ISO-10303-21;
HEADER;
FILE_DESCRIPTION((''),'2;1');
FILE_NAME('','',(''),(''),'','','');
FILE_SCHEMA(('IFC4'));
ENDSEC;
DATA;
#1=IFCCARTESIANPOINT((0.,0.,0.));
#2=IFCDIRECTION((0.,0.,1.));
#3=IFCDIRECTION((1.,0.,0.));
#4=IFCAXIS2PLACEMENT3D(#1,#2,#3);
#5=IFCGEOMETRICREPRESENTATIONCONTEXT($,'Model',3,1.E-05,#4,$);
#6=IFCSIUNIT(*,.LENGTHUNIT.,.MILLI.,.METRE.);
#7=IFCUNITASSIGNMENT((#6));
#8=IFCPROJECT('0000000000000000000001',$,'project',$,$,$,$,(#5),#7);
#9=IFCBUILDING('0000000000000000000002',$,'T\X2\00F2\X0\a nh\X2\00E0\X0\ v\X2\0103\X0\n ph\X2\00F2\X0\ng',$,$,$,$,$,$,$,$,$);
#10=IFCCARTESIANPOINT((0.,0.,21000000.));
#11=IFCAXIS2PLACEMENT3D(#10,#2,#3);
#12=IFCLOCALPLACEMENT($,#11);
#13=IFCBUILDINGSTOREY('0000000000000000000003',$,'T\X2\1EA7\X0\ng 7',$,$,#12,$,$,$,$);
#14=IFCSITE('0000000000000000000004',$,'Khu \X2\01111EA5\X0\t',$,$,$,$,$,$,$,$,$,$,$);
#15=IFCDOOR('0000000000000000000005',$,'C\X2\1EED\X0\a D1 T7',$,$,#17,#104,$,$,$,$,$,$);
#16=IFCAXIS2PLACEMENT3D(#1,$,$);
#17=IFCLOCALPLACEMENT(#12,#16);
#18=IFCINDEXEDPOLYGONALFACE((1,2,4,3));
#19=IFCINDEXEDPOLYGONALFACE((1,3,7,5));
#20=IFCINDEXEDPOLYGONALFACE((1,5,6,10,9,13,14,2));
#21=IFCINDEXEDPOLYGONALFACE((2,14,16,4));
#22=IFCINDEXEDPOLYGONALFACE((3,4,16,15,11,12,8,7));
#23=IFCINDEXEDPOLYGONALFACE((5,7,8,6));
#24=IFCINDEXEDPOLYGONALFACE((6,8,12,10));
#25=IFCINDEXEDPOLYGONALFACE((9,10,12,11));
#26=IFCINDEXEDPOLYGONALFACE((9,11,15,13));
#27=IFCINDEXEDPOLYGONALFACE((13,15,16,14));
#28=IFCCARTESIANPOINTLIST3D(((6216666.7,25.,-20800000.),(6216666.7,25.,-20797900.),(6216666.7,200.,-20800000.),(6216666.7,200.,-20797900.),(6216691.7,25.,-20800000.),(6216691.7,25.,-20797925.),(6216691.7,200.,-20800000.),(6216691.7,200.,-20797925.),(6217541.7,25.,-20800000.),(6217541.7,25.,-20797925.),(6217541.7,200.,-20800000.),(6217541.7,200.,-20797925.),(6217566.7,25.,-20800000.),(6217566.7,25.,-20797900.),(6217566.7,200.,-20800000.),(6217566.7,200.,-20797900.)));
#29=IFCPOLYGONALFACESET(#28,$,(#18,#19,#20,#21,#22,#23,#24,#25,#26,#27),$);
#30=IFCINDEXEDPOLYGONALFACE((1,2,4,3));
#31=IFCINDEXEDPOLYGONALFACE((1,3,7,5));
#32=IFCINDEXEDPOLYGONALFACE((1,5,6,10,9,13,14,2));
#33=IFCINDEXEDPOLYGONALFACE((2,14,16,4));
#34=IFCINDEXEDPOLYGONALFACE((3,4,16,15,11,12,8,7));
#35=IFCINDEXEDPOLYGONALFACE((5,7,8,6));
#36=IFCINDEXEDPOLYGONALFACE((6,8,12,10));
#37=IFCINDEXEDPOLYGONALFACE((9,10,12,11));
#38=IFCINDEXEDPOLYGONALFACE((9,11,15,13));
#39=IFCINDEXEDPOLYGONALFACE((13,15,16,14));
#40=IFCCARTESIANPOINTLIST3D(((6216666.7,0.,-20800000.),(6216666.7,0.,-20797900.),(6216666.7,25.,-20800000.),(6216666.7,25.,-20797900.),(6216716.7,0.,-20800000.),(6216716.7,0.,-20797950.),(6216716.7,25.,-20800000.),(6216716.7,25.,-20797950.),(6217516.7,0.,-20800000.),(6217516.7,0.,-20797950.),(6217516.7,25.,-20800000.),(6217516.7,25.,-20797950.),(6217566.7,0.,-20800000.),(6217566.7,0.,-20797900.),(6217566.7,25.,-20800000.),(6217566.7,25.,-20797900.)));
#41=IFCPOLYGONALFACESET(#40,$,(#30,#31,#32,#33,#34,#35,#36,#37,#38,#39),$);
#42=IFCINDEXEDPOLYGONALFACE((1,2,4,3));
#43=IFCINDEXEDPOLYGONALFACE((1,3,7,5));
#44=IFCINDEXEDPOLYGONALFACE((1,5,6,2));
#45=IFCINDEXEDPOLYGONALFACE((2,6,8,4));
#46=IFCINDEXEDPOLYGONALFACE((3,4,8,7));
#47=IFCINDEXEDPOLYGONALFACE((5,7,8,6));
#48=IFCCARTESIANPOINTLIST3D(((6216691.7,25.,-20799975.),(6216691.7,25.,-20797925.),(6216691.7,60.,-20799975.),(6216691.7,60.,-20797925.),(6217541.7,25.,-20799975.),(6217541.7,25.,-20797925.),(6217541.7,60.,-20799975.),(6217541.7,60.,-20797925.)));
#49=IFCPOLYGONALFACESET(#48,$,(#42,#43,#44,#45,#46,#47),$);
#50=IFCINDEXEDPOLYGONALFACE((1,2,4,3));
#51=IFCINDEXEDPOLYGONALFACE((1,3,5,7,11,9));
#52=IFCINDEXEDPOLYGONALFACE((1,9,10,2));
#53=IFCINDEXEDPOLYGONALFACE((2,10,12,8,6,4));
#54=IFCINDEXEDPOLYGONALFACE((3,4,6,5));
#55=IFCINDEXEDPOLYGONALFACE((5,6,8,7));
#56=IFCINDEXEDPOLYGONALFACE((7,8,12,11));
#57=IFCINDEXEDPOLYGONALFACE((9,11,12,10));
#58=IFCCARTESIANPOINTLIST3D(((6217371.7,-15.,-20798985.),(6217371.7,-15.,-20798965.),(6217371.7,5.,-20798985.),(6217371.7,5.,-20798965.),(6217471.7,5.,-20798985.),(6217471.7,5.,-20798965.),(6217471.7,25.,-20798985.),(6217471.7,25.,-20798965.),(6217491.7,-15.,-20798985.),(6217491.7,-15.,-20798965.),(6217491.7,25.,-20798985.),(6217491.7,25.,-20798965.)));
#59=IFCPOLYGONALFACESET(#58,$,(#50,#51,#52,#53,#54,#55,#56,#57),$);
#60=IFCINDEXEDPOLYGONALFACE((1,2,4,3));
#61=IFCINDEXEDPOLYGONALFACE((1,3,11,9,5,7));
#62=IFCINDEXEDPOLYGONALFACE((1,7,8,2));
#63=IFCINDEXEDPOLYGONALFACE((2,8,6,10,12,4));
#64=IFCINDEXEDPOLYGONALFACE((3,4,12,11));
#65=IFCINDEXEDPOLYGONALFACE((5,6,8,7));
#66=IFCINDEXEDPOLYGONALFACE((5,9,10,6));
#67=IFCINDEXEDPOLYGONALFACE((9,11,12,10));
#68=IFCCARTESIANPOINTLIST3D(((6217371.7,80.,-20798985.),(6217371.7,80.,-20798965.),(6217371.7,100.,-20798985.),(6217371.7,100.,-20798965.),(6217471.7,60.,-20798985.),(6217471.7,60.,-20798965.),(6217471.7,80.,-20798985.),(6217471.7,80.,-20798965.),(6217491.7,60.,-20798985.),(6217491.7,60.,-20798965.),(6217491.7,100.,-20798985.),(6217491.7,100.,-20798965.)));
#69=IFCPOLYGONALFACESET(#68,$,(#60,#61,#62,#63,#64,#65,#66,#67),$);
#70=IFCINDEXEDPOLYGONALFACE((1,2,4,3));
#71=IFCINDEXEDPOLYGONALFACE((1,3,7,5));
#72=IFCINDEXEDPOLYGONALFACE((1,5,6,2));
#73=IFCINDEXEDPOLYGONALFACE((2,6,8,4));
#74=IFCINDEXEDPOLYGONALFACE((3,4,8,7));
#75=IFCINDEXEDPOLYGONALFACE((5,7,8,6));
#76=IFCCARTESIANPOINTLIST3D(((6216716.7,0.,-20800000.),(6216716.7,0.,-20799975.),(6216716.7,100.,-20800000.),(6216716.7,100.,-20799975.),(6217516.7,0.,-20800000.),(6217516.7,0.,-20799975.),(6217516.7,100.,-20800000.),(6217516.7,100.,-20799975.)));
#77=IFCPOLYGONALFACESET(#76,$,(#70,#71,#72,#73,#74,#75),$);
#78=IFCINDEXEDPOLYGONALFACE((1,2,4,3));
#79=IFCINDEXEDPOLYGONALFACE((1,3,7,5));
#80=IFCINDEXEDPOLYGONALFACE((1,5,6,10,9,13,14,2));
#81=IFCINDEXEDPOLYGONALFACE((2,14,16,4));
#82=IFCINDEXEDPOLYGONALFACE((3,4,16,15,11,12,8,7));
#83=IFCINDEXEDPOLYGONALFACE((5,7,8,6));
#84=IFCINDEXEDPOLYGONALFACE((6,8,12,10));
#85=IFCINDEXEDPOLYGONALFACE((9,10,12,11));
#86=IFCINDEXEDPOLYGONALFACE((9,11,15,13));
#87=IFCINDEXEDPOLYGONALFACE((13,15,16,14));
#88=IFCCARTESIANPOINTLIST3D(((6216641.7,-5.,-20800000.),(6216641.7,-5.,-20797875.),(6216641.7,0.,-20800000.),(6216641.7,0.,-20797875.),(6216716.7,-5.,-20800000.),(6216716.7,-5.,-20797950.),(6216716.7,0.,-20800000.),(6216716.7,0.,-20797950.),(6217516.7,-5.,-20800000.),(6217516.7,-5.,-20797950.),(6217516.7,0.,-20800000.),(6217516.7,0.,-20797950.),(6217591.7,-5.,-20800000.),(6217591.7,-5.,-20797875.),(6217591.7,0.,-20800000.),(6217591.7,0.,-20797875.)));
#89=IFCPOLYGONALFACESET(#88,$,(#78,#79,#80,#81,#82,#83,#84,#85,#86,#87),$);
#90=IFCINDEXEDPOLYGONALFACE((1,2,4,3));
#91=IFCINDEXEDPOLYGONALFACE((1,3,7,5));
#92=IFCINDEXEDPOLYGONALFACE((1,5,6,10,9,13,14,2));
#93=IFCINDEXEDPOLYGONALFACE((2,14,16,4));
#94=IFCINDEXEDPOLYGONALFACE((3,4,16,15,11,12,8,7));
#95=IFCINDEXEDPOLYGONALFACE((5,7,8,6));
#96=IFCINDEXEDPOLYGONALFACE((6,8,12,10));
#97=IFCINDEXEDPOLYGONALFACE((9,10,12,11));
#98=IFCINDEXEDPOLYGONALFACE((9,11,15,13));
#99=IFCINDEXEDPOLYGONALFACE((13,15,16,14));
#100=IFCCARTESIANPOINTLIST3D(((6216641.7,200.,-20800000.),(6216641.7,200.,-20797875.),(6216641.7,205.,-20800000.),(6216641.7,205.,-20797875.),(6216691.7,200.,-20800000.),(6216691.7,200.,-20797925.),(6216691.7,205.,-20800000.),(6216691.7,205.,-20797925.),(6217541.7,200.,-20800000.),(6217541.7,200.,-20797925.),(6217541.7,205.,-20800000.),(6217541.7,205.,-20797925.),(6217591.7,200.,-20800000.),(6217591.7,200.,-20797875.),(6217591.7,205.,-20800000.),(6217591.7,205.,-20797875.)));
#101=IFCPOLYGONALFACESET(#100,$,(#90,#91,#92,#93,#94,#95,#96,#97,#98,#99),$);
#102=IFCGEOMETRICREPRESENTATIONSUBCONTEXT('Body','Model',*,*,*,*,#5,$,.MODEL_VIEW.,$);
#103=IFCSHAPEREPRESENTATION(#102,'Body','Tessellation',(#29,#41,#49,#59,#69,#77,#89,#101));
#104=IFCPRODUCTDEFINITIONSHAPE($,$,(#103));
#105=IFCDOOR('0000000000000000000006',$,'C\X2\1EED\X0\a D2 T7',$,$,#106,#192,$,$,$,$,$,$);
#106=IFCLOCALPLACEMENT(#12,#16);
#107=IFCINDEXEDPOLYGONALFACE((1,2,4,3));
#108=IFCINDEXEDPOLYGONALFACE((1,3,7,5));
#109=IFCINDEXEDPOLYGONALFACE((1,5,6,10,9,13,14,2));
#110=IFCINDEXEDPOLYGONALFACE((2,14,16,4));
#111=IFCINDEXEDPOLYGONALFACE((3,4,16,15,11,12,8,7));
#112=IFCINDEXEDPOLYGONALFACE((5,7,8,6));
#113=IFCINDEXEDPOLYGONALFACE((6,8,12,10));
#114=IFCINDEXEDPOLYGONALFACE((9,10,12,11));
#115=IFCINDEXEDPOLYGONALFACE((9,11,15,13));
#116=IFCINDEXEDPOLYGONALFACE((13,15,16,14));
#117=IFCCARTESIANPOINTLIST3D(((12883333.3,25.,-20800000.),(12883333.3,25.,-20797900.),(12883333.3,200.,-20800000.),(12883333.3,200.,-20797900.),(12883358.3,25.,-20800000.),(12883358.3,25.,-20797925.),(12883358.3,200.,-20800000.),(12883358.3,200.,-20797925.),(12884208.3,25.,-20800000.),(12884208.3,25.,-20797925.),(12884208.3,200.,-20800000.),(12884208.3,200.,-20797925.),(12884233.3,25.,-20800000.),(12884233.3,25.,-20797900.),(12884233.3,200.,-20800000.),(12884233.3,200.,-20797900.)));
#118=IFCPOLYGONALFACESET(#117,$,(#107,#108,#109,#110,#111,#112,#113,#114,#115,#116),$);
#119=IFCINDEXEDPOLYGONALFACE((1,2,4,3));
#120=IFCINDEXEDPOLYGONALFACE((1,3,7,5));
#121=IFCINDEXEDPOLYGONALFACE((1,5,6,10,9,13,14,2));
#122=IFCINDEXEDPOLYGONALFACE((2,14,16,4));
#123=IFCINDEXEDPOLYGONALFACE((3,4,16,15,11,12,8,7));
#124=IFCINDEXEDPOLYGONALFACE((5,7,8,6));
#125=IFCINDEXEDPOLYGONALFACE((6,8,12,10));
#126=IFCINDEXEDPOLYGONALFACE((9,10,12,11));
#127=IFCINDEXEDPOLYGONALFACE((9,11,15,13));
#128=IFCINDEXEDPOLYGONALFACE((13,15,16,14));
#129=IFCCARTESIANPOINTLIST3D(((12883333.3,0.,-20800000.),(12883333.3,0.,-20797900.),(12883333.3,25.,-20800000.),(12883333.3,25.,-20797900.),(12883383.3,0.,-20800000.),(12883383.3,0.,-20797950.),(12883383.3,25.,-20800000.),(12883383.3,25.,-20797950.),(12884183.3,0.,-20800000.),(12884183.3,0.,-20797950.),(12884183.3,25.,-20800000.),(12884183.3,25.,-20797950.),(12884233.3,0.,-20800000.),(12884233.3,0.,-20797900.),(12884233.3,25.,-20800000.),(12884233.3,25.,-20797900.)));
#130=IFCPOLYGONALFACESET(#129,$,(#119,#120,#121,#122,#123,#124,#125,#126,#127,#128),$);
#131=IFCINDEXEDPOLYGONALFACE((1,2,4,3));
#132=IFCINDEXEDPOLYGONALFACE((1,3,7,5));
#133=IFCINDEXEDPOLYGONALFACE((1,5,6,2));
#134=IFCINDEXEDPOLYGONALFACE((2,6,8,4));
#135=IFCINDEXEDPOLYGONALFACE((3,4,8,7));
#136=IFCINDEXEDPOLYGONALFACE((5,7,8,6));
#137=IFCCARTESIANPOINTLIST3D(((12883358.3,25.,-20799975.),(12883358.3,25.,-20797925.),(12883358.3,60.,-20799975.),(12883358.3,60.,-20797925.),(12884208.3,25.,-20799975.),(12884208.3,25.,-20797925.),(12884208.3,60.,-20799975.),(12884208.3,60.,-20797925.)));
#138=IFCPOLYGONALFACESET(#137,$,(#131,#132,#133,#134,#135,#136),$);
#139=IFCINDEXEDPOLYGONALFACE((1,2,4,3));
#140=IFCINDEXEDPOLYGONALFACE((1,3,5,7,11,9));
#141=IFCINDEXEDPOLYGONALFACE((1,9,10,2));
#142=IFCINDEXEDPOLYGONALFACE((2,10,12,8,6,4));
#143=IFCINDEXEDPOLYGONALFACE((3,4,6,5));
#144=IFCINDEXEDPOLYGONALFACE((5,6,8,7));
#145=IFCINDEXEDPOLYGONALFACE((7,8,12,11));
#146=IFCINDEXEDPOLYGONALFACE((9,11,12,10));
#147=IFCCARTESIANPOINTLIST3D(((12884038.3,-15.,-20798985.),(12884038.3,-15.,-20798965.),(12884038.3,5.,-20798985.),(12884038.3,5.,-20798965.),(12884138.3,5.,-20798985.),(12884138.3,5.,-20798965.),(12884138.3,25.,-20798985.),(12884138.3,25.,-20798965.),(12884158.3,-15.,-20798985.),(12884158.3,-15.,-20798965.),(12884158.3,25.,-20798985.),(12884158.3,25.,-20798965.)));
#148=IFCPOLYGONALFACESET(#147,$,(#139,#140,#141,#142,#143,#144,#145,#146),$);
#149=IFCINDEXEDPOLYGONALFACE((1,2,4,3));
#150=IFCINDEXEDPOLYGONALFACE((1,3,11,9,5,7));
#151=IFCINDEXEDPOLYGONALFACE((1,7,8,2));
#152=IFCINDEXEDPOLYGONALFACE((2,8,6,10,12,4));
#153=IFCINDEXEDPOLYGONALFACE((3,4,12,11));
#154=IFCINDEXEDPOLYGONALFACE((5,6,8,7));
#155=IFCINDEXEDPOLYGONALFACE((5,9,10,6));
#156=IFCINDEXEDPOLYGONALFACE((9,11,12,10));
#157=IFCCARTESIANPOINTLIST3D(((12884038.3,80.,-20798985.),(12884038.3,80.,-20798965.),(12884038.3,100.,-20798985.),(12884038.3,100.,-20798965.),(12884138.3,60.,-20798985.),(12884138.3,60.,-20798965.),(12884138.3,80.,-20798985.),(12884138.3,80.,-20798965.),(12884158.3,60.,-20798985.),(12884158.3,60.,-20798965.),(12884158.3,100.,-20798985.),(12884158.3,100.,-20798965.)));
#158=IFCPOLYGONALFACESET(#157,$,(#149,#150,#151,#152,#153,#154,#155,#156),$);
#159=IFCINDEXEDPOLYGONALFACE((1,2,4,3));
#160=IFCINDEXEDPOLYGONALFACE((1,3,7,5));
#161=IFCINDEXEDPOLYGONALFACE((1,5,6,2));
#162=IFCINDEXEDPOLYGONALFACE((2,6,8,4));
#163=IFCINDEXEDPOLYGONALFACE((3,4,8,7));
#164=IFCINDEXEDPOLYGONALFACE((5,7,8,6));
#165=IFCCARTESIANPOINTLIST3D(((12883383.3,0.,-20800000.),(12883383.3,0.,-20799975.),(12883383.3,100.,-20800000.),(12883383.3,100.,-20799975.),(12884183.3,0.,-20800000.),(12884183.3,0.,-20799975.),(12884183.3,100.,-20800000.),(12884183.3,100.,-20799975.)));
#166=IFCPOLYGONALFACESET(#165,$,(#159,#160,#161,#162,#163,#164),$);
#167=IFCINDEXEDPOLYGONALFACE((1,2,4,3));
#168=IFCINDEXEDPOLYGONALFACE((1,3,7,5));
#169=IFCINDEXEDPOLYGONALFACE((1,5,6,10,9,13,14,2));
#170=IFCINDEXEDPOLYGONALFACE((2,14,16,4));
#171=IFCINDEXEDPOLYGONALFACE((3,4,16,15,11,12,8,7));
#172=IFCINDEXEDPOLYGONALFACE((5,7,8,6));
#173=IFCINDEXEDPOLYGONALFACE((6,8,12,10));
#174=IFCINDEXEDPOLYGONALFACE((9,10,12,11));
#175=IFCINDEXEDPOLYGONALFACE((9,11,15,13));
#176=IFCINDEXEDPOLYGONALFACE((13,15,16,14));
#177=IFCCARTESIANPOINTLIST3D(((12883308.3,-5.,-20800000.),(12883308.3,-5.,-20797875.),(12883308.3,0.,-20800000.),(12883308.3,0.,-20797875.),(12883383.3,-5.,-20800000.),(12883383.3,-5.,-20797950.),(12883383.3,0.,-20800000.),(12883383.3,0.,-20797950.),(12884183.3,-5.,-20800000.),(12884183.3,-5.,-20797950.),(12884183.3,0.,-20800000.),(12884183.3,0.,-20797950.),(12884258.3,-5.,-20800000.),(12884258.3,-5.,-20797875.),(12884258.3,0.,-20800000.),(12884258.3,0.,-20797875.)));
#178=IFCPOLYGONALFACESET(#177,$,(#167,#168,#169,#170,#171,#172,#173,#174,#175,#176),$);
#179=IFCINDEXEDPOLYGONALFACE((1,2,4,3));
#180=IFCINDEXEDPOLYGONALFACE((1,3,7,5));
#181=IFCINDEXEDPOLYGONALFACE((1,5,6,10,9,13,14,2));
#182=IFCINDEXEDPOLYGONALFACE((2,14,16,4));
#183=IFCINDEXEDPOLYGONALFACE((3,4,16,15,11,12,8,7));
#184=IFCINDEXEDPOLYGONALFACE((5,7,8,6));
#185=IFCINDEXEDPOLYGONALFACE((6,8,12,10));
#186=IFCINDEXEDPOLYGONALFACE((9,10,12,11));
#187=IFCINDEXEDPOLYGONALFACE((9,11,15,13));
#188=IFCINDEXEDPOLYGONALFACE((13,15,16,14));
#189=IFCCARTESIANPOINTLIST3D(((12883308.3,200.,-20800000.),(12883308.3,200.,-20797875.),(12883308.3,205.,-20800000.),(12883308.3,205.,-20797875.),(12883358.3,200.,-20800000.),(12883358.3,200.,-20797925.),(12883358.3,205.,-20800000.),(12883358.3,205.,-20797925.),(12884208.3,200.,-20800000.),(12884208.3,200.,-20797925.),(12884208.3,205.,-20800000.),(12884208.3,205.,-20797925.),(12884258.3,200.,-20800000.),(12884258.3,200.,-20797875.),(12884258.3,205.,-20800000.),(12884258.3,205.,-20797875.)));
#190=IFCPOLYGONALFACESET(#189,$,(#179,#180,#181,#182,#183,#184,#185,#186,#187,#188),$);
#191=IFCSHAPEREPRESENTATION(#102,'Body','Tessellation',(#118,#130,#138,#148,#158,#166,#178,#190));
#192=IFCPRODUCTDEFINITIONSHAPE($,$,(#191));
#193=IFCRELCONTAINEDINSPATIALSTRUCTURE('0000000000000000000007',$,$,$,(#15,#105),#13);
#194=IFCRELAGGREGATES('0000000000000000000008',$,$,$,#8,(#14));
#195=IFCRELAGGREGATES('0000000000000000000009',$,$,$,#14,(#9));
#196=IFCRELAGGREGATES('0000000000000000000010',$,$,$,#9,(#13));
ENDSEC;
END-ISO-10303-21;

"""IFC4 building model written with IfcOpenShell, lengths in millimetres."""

from ifc_helpers import new_model, si_unit, frame, origin_with_axes, place, context, subcontext, project, spatial, line, indexed_curve, outline, extrude, element, save


model = new_model("IFC4")

# Units and contexts
model_context = context("Model", 3, precision=1e-05, world=origin_with_axes())
body_context = subcontext(model_context, "Body", "Model", "MODEL_VIEW")
ifc_project = project(units=[si_unit("LENGTHUNIT", "METRE", prefix="MILLI")], contexts=[model_context])

# Site, building, storey
site = spatial("IfcSite", under=ifc_project, Name="Khu đất")
building = spatial("IfcBuilding", under=site, Name="Tòa nhà văn phòng")
storey_placement = place(None, frame((0.0, 0.0, 21000000.0), z_axis=(0.0, 0.0, 1.0), x_axis=(1.0, 0.0, 0.0)))
storey = spatial("IfcBuildingStorey", under=building, at=storey_placement, Name="Tầng 7")

# Doors
door_1_placement = place(storey_placement, frame((6216666.7, 0.0, -20800000.0), z_axis=(0.0, 0.0, 1.0), x_axis=(1.0, 0.0, 0.0)))
element("IfcDoor", 1, at=door_1_placement, inside=storey, Name="Cửa D1 T7", context=body_context, shape_type="SolidModel", body=[
    extrude(outline(indexed_curve([(0.0, 0.0), (0.0, 2100.0), (900.0, 2100.0), (900.0, 0.0), (875.0, 0.0), (875.0, 2075.0), (25.0, 2075.0), (25.0, 0.0)], segments=[line(1, 2, 3, 4, 5, 6, 7, 8, 1)])), frame((0.0, 25.0, 0.0), z_axis=(0.0, -1.0, 0.0), x_axis=(1.0, 0.0, 0.0)), (0.0, 0.0, -1.0), 175.0),
    extrude(outline(indexed_curve([(0.0, 0.0), (0.0, 2100.0), (900.0, 2100.0), (900.0, 0.0), (850.0, 0.0), (850.0, 2050.0), (50.0, 2050.0), (50.0, 0.0)], segments=[line(1, 2, 3, 4, 5, 6, 7, 8, 1)])), frame((0.0, 0.0, 0.0), z_axis=(0.0, -1.0, 0.0), x_axis=(1.0, 0.0, 0.0)), (0.0, 0.0, -1.0), 25.0),
    extrude(outline(indexed_curve([(0.0, 0.0), (850.0, 0.0), (850.0, 35.0), (0.0, 35.0)], segments=[line(1, 2, 3, 4, 1)])), frame((25.0, 25.0, 25.0), z_axis=(0.0, 0.0, 1.0), x_axis=(1.0, 0.0, 0.0)), (0.0, 0.0, 1.0), 2050.0),
    extrude(outline(indexed_curve([(0.0, 0.0), (0.0, -40.0), (-120.0, -40.0), (-120.0, -20.0), (-20.0, -20.0), (-20.0, 0.0)], segments=[line(1, 2, 3, 4, 5, 6, 1)])), frame((825.0, 25.0, 1015.0), z_axis=(0.0, 0.0, 1.0), x_axis=(1.0, 0.0, 0.0)), (0.0, 0.0, 1.0), 20.0),
    extrude(outline(indexed_curve([(0.0, 0.0), (0.0, 40.0), (-120.0, 40.0), (-120.0, 20.0), (-20.0, 20.0), (-20.0, 0.0)], segments=[line(1, 2, 3, 4, 5, 6, 1)])), frame((825.0, 60.0, 1015.0), z_axis=(0.0, 0.0, 1.0), x_axis=(1.0, 0.0, 0.0)), (0.0, 0.0, 1.0), 20.0),
    extrude(outline(indexed_curve([(0.0, 0.0), (800.0, 0.0), (800.0, 100.0), (0.0, 100.0)], segments=[line(1, 2, 3, 4, 1)])), frame((50.0, 0.0, 0.0), z_axis=(0.0, 0.0, 1.0), x_axis=(1.0, 0.0, 0.0)), (0.0, 0.0, 1.0), 25.0),
    extrude(outline(indexed_curve([(0.0, 0.0), (0.0, 2125.0), (950.0, 2125.0), (950.0, 0.0), (875.0, 0.0), (875.0, 2050.0), (75.0, 2050.0), (75.0, 0.0)], segments=[line(1, 2, 3, 4, 5, 6, 7, 8, 1)])), frame((-25.0, -5.0, 0.0), z_axis=(0.0, -1.0, 0.0), x_axis=(1.0, 0.0, 0.0)), (0.0, 0.0, -1.0), 5.0),
    extrude(outline(indexed_curve([(0.0, 0.0), (0.0, 2125.0), (950.0, 2125.0), (950.0, 0.0), (900.0, 0.0), (900.0, 2075.0), (50.0, 2075.0), (50.0, 0.0)], segments=[line(1, 2, 3, 4, 5, 6, 7, 8, 1)])), frame((-25.0, 200.0, 0.0), z_axis=(0.0, -1.0, 0.0), x_axis=(1.0, 0.0, 0.0)), (0.0, 0.0, -1.0), 5.0),
])
door_2_placement = place(storey_placement, frame((12883333.3, 0.0, -20800000.0), z_axis=(0.0, 0.0, 1.0), x_axis=(1.0, 0.0, 0.0)))
element("IfcDoor", 2, at=door_2_placement, inside=storey, Name="Cửa D2 T7", context=body_context, shape_type="SolidModel", body=[
    extrude(outline(indexed_curve([(0.0, 0.0), (0.0, 2100.0), (900.0, 2100.0), (900.0, 0.0), (875.0, 0.0), (875.0, 2075.0), (25.0, 2075.0), (25.0, 0.0)], segments=[line(1, 2, 3, 4, 5, 6, 7, 8, 1)])), frame((0.0, 25.0, 0.0), z_axis=(0.0, -1.0, 0.0), x_axis=(1.0, 0.0, 0.0)), (0.0, 0.0, -1.0), 175.0),
    extrude(outline(indexed_curve([(0.0, 0.0), (0.0, 2100.0), (900.0, 2100.0), (900.0, 0.0), (850.0, 0.0), (850.0, 2050.0), (50.0, 2050.0), (50.0, 0.0)], segments=[line(1, 2, 3, 4, 5, 6, 7, 8, 1)])), frame((0.0, 0.0, 0.0), z_axis=(0.0, -1.0, 0.0), x_axis=(1.0, 0.0, 0.0)), (0.0, 0.0, -1.0), 25.0),
    extrude(outline(indexed_curve([(0.0, 0.0), (850.0, 0.0), (850.0, 35.0), (0.0, 35.0)], segments=[line(1, 2, 3, 4, 1)])), frame((25.0, 25.0, 25.0), z_axis=(0.0, 0.0, 1.0), x_axis=(1.0, 0.0, 0.0)), (0.0, 0.0, 1.0), 2050.0),
    extrude(outline(indexed_curve([(0.0, 0.0), (0.0, -40.0), (-120.0, -40.0), (-120.0, -20.0), (-20.0, -20.0), (-20.0, 0.0)], segments=[line(1, 2, 3, 4, 5, 6, 1)])), frame((825.0, 25.0, 1015.0), z_axis=(0.0, 0.0, 1.0), x_axis=(1.0, 0.0, 0.0)), (0.0, 0.0, 1.0), 20.0),
    extrude(outline(indexed_curve([(0.0, 0.0), (0.0, 40.0), (-120.0, 40.0), (-120.0, 20.0), (-20.0, 20.0), (-20.0, 0.0)], segments=[line(1, 2, 3, 4, 5, 6, 1)])), frame((825.0, 60.0, 1015.0), z_axis=(0.0, 0.0, 1.0), x_axis=(1.0, 0.0, 0.0)), (0.0, 0.0, 1.0), 20.0),
    extrude(outline(indexed_curve([(0.0, 0.0), (800.0, 0.0), (800.0, 100.0), (0.0, 100.0)], segments=[line(1, 2, 3, 4, 1)])), frame((50.0, 0.0, 0.0), z_axis=(0.0, 0.0, 1.0), x_axis=(1.0, 0.0, 0.0)), (0.0, 0.0, 1.0), 25.0),
    extrude(outline(indexed_curve([(0.0, 0.0), (0.0, 2125.0), (950.0, 2125.0), (950.0, 0.0), (875.0, 0.0), (875.0, 2050.0), (75.0, 2050.0), (75.0, 0.0)], segments=[line(1, 2, 3, 4, 5, 6, 7, 8, 1)])), frame((-25.0, -5.0, 0.0), z_axis=(0.0, -1.0, 0.0), x_axis=(1.0, 0.0, 0.0)), (0.0, 0.0, -1.0), 5.0),
    extrude(outline(indexed_curve([(0.0, 0.0), (0.0, 2125.0), (950.0, 2125.0), (950.0, 0.0), (900.0, 0.0), (900.0, 2075.0), (50.0, 2075.0), (50.0, 0.0)], segments=[line(1, 2, 3, 4, 5, 6, 7, 8, 1)])), frame((-25.0, 200.0, 0.0), z_axis=(0.0, -1.0, 0.0), x_axis=(1.0, 0.0, 0.0)), (0.0, 0.0, -1.0), 5.0),
])

save(model, "model.ifc")
